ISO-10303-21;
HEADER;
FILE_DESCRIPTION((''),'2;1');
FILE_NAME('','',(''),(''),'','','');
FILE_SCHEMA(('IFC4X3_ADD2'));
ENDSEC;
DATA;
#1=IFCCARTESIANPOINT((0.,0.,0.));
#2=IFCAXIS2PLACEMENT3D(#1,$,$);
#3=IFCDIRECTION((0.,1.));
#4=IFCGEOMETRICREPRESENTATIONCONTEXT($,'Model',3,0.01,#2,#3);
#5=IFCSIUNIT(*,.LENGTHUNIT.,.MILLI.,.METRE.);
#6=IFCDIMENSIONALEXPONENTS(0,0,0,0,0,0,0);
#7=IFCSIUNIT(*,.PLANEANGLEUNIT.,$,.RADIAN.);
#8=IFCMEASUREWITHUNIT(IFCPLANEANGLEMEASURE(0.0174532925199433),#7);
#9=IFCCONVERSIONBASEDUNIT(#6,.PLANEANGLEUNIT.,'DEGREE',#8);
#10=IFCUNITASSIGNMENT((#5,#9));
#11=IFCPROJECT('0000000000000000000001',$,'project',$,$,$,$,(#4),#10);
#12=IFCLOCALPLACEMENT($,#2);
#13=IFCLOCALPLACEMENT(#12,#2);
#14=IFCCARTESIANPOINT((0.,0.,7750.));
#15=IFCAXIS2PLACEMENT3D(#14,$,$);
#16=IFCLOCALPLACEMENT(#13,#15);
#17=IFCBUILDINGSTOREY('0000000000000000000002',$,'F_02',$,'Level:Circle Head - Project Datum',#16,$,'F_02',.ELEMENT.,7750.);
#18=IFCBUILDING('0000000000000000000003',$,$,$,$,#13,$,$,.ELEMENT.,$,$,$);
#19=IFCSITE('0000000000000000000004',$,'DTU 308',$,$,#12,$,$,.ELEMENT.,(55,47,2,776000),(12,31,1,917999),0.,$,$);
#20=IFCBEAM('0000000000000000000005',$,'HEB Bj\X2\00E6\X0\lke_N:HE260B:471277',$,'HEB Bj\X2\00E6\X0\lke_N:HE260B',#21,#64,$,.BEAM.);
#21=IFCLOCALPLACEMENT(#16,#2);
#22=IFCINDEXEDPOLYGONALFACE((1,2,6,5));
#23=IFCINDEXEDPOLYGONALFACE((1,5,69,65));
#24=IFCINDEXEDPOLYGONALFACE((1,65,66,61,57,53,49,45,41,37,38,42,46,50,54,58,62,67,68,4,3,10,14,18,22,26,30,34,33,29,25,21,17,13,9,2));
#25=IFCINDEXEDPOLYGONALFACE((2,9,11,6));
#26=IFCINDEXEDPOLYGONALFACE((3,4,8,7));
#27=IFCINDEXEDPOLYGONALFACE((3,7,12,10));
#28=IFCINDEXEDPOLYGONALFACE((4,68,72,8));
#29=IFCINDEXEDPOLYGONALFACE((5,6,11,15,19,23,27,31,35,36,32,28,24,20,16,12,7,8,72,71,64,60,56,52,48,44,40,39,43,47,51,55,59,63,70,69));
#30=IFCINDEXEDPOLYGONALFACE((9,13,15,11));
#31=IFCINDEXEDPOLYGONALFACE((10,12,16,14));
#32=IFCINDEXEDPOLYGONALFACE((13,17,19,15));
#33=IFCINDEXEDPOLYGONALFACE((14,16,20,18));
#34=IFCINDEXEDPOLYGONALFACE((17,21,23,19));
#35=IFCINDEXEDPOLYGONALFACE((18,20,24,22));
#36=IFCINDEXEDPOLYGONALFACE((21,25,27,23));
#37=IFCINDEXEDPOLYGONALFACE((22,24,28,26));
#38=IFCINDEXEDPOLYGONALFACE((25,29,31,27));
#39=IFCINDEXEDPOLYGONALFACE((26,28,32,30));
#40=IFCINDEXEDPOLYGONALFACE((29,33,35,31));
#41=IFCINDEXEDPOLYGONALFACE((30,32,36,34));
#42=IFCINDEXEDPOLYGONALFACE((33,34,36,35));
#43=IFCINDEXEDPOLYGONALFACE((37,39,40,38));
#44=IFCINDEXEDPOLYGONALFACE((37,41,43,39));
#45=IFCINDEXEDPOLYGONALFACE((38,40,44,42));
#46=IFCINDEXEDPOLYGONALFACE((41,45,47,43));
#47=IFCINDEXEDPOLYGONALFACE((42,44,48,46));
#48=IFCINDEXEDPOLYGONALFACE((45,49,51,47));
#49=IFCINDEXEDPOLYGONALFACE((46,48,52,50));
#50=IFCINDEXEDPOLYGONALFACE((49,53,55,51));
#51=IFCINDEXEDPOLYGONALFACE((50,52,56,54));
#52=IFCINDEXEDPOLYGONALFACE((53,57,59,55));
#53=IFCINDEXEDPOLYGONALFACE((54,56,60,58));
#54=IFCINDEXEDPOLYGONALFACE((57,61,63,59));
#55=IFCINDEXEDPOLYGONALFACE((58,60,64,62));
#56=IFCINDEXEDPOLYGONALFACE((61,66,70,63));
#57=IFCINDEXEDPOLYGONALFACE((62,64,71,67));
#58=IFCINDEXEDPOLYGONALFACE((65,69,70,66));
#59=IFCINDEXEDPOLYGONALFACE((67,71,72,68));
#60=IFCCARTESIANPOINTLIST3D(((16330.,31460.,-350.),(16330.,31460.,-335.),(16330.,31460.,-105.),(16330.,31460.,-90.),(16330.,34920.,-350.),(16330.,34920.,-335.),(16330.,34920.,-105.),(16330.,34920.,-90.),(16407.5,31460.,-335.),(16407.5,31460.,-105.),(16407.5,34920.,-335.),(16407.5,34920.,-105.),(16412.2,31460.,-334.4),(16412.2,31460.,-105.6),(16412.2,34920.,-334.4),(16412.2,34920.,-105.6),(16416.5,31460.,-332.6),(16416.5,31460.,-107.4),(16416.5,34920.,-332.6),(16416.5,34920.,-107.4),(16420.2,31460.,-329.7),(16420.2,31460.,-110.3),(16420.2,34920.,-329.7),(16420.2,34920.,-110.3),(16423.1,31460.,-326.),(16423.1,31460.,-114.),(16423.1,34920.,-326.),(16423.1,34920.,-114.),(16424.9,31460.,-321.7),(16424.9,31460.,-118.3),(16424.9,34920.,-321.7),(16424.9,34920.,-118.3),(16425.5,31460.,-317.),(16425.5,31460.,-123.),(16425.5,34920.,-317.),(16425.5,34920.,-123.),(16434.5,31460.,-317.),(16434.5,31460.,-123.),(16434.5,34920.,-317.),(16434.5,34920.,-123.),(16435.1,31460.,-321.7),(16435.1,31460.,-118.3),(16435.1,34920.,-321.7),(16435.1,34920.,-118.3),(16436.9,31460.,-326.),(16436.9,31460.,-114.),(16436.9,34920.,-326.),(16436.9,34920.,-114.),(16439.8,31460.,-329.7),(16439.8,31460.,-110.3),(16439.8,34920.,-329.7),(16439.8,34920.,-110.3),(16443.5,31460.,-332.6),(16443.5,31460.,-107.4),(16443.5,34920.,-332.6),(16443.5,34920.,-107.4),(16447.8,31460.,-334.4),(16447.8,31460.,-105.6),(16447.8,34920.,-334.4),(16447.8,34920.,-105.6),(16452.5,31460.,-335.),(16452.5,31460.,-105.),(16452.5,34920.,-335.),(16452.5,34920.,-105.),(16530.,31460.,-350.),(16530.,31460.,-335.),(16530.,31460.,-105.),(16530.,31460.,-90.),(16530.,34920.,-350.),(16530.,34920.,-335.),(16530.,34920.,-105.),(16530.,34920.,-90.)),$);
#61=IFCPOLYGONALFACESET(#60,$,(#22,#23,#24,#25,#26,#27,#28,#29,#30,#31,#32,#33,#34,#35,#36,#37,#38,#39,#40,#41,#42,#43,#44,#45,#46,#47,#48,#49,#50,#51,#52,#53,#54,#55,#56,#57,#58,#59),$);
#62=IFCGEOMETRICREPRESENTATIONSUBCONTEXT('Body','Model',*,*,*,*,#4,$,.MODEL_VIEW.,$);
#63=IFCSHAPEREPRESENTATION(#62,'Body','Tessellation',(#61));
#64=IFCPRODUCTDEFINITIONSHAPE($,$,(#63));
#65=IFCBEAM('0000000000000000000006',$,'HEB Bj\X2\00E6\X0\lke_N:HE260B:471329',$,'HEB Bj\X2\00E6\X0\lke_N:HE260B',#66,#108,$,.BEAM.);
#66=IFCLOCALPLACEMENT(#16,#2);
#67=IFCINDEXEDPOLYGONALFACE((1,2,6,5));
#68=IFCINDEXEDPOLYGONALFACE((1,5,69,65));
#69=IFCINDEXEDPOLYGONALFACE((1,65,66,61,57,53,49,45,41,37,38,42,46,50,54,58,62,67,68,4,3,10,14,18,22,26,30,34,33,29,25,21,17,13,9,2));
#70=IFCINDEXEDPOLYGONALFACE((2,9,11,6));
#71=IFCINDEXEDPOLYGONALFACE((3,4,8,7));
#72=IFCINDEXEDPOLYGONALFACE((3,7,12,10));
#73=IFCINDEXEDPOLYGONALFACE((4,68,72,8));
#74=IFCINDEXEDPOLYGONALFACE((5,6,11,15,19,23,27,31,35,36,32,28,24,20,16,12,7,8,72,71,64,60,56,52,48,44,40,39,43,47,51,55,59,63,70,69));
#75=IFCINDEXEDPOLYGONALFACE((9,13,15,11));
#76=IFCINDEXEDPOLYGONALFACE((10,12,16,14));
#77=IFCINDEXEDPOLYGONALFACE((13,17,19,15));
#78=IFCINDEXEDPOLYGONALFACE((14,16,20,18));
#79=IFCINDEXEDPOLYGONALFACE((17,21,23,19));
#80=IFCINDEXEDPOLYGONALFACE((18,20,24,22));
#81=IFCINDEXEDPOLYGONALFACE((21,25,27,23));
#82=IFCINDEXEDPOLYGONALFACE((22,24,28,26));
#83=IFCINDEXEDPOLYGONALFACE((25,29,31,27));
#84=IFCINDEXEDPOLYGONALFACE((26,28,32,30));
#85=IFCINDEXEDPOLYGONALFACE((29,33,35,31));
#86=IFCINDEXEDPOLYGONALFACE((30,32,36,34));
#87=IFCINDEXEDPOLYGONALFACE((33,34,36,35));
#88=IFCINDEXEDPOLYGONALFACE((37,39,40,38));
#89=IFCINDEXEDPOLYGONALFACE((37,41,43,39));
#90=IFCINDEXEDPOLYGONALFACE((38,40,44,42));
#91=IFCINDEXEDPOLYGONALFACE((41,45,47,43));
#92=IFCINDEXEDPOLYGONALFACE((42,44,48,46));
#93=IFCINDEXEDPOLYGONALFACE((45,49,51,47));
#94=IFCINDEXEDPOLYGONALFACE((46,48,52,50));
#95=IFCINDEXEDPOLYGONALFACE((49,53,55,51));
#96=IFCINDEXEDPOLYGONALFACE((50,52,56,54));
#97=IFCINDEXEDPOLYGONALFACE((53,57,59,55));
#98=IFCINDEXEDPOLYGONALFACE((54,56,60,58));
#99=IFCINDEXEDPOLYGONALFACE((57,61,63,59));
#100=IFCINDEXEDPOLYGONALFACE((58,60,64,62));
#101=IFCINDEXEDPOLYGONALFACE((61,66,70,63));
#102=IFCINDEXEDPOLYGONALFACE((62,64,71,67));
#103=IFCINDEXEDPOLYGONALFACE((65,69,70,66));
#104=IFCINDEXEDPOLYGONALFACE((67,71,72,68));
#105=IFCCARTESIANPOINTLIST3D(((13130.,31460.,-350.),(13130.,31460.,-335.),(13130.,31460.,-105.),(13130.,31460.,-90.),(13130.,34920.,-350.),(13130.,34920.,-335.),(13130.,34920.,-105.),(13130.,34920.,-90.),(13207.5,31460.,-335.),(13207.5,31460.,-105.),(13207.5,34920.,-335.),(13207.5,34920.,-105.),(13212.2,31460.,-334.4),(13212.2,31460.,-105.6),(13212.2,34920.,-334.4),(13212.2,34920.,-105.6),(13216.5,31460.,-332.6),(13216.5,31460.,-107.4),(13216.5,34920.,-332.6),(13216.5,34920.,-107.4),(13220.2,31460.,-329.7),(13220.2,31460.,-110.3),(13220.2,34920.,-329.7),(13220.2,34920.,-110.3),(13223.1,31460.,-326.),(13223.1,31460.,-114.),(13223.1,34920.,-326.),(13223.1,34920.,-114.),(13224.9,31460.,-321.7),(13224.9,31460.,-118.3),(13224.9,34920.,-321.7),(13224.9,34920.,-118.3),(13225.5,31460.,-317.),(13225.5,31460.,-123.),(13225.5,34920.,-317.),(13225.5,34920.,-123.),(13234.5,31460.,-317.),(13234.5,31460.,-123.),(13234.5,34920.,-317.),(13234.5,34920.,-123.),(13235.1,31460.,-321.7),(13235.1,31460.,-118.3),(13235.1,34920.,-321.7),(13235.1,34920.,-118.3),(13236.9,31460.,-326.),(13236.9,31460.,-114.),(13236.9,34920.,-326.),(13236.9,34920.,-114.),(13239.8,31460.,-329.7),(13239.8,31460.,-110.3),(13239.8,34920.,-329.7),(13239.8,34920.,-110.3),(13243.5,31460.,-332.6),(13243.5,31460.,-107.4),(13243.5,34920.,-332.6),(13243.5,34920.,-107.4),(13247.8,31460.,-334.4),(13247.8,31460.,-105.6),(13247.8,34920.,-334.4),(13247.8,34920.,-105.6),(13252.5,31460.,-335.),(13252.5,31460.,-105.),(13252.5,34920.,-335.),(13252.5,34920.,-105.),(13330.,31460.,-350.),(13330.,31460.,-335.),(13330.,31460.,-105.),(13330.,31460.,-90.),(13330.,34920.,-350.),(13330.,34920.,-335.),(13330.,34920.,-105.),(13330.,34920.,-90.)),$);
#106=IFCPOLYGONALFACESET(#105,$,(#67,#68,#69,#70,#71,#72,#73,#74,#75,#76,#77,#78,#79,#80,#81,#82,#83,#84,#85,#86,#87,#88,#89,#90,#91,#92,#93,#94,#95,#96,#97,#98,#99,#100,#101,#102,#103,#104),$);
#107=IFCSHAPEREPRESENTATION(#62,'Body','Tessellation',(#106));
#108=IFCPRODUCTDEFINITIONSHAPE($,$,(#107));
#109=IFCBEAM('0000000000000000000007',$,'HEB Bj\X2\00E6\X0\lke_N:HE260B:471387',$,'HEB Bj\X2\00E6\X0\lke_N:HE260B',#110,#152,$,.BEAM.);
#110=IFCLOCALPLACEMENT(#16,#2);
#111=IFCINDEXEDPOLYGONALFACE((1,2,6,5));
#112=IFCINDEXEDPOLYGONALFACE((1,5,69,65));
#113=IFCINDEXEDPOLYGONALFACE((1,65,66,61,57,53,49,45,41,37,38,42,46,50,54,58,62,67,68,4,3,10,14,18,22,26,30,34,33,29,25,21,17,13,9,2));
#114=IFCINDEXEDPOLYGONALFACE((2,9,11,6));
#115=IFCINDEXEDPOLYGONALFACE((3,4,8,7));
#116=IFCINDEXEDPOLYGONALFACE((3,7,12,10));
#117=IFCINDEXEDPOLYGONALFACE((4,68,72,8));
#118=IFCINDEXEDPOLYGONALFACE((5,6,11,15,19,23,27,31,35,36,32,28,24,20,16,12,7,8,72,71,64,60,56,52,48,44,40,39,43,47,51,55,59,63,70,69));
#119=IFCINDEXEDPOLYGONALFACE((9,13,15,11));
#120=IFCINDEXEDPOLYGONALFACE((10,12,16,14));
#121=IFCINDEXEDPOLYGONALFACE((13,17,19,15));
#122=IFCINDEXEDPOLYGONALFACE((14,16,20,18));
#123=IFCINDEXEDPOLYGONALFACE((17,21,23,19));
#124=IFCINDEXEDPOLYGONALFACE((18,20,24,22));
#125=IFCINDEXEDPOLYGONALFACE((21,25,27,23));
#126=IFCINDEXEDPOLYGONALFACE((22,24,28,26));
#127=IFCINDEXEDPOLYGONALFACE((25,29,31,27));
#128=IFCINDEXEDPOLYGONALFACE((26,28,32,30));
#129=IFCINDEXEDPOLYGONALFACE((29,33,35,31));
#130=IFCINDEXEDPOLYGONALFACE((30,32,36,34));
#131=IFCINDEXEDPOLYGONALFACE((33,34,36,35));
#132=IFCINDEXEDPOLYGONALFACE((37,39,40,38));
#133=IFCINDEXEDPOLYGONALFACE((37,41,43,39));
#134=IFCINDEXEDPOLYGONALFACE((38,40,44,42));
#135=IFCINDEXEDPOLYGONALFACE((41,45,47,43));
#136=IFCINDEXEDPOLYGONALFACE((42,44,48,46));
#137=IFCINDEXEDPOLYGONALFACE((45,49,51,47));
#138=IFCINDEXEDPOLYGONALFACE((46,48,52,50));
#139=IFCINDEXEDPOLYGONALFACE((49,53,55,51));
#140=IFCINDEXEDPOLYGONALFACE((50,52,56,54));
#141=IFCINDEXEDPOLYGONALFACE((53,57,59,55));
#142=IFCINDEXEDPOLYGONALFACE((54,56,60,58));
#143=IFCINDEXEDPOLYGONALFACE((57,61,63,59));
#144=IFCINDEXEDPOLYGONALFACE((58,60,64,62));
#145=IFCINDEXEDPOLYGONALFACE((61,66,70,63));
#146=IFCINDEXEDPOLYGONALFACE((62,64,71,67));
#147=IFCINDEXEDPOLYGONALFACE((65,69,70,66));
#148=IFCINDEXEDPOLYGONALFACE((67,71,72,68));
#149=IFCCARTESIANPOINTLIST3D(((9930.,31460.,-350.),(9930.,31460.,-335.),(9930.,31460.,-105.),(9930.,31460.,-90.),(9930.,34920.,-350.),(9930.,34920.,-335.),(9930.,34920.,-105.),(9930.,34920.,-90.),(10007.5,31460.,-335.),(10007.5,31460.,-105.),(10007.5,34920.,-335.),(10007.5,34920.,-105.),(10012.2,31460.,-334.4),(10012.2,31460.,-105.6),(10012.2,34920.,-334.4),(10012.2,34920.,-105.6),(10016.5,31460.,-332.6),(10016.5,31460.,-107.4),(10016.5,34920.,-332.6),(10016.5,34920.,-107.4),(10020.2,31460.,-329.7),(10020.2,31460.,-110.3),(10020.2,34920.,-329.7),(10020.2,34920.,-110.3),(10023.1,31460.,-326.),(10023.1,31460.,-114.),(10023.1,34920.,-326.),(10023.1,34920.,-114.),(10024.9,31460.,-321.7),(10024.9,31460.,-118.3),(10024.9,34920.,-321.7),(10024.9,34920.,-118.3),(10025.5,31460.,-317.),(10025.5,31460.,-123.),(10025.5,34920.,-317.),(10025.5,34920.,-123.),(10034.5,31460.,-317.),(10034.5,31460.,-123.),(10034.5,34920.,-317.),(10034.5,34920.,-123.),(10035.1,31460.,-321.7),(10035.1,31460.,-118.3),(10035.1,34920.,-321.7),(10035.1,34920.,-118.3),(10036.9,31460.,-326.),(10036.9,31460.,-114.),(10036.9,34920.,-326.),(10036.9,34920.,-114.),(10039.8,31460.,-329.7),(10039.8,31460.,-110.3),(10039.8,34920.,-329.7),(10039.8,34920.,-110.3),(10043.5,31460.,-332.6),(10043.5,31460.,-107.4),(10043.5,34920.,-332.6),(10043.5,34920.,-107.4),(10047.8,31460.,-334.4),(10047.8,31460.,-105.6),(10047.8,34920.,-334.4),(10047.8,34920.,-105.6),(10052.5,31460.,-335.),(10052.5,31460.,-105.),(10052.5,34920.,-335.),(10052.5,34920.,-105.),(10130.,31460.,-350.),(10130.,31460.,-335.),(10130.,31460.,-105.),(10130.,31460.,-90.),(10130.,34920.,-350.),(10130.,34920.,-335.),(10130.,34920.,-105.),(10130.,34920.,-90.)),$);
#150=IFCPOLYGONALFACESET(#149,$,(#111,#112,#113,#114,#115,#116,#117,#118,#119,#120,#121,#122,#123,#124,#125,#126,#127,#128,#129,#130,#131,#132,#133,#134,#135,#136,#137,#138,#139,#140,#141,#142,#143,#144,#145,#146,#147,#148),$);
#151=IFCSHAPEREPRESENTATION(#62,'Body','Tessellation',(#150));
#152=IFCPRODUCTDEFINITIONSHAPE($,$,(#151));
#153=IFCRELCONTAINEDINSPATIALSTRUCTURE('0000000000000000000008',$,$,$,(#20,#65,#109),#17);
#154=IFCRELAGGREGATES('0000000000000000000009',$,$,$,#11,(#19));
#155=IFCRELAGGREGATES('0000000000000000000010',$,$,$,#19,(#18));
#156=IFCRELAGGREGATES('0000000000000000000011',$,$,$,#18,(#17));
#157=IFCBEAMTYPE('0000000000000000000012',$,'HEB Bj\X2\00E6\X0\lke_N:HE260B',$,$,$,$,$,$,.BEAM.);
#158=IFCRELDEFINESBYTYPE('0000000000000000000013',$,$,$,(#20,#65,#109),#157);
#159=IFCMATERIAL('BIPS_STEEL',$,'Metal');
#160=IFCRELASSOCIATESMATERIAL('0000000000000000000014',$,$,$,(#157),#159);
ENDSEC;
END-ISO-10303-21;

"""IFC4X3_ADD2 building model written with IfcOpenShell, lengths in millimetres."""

from ifc_helpers import new_model, entity, si_unit, converted_unit, direction, frame, frame_2d, origin, place, context, subcontext, project, spatial, polyline, circle_curve, parameter, trimmed, segment, composite_curve, i_section, outline, extrude, source, transform, mapped, material, material_profile, profile_set, type_object, element, save


model = new_model("IFC4X3_ADD2")

# Units and contexts
model_context = context("Model", 3, precision=0.01, world=origin(), true_north=direction((0.0, 1.0)))
body_context = subcontext(model_context, "Body", "Model", "MODEL_VIEW")
ifc_project = project(units=[si_unit("LENGTHUNIT", "METRE", prefix="MILLI"), converted_unit("PLANEANGLEUNIT", "DEGREE", entity("IfcPlaneAngleMeasure", 0.0174532925199433), si_unit("PLANEANGLEUNIT", "RADIAN"), dimensions=[0, 0, 0, 0, 0, 0, 0])], contexts=[model_context])

# Site, building, storey
site_placement = place(None, origin())
site = spatial("IfcSite", under=ifc_project, at=site_placement, Name="DTU 308", CompositionType="ELEMENT", RefLatitude=(55, 47, 2, 776000), RefLongitude=(12, 31, 1, 917999), RefElevation=0.0)
building_placement = place(site_placement, origin())
building = spatial("IfcBuilding", under=site, at=building_placement, CompositionType="ELEMENT")
storey_placement = place(building_placement, frame((0.0, 0.0, 7750.0)))
storey = spatial("IfcBuildingStorey", under=building, at=storey_placement, Name="F_02", ObjectType="Level:Circle Head - Project Datum", LongName="F_02", CompositionType="ELEMENT", Elevation=7750.0)

# Shared definitions
ifc_material = material(Name="BIPS_STEEL", Category="Metal")

# Beams
ifc_material_profile_1 = material_profile(ifc_material, i_section(OverallWidth=200.0, OverallDepth=260.0, WebThickness=9.0, FlangeThickness=15.0, FilletRadius=18.0, at=frame_2d((0.0, 0.0), x_axis=(1.0, 0.0))), Name="HE260B")
ifc_profile_set_1 = profile_set([ifc_material_profile_1], Name="HE260B")
beam_type_1 = type_object("IfcBeamType", Name="HEB Bjælke_N:HE260B", PredefinedType="BEAM", material=ifc_profile_set_1)
shared_shape_1 = source(origin(), body_context, "Body", "SweptSolid", [
    extrude(outline(composite_curve([segment(polyline([(-100.0, -115.0), (-100.0, -130.0)]), True, "CONTINUOUS"), segment(polyline([(-100.0, -130.0), (100.0, -130.0)]), True, "CONTINUOUS"), segment(polyline([(100.0, -130.0), (100.0, -115.0)]), True, "CONTINUOUS"), segment(polyline([(100.0, -115.0), (22.5, -115.0)]), True, "CONTINUOUS"), segment(trimmed(circle_curve(frame_2d((22.5, -97.0), x_axis=(1.0, 0.0)), 18.0), [parameter(180.0)], [parameter(270.0)], True, "PARAMETER"), False, "CONTINUOUS"), segment(polyline([(4.5, -97.0), (4.5, 97.0)]), True, "CONTINUOUS"), segment(trimmed(circle_curve(frame_2d((22.5, 97.0), x_axis=(1.0, 0.0)), 18.0), [parameter(90.0)], [parameter(180.0)], True, "PARAMETER"), False, "CONTINUOUS"), segment(polyline([(22.5, 115.0), (100.0, 115.0)]), True, "CONTINUOUS"), segment(polyline([(100.0, 115.0), (100.0, 130.0)]), True, "CONTINUOUS"), segment(polyline([(100.0, 130.0), (-100.0, 130.0)]), True, "CONTINUOUS"), segment(polyline([(-100.0, 130.0), (-100.0, 115.0)]), True, "CONTINUOUS"), segment(polyline([(-100.0, 115.0), (-22.5, 115.0)]), True, "CONTINUOUS"), segment(trimmed(circle_curve(frame_2d((-22.5, 97.0), x_axis=(1.0, 0.0)), 18.0), [parameter(360.0)], [parameter(90.0)], True, "PARAMETER"), False, "CONTINUOUS"), segment(polyline([(-4.5, 97.0), (-4.5, -97.0)]), True, "CONTINUOUS"), segment(trimmed(circle_curve(frame_2d((-22.5, -97.0), x_axis=(1.0, 0.0)), 18.0), [parameter(270.0)], [parameter(360.0)], True, "PARAMETER"), False, "CONTINUOUS"), segment(polyline([(-22.5, -115.0), (-100.0, -115.0)]), True, "CONTINUOUS")], self_intersect=False)), frame((-1720.0, 0.0, 0.0), z_axis=(-1.0, 0.0, 0.0), x_axis=(0.0, -1.0, 0.0)), (0.0, 0.0, -1.0), 3460.0),
])
for number, where, z_axis, x_axis, name in (
    (1, (16430.0, 33200.0, -220.0), (0.0, 0.0, 1.0), (0.0, -1.0, 0.0), "HEB Bjælke_N:HE260B:471277"),
    (2, (13230.0, 33200.0, -220.0), (0.0, 0.0, 1.0), (0.0, -1.0, 0.0), "HEB Bjælke_N:HE260B:471329"),
    (3, (10030.0, 33200.0, -220.0), (0.0, 0.0, 1.0), (0.0, -1.0, 0.0), "HEB Bjælke_N:HE260B:471387"),
):
    element("IfcBeam", number, at=place(storey_placement, frame(where, z_axis=z_axis, x_axis=x_axis)), inside=storey, type_object=beam_type_1, Name=name, ObjectType="HEB Bjælke_N:HE260B", PredefinedType="BEAM", context=body_context, shape_type="MappedRepresentation", body=[
        mapped(shared_shape_1, transform((0.0, 0.0, 0.0), scale=1.0)),
    ])

save(model, "model.ifc")
